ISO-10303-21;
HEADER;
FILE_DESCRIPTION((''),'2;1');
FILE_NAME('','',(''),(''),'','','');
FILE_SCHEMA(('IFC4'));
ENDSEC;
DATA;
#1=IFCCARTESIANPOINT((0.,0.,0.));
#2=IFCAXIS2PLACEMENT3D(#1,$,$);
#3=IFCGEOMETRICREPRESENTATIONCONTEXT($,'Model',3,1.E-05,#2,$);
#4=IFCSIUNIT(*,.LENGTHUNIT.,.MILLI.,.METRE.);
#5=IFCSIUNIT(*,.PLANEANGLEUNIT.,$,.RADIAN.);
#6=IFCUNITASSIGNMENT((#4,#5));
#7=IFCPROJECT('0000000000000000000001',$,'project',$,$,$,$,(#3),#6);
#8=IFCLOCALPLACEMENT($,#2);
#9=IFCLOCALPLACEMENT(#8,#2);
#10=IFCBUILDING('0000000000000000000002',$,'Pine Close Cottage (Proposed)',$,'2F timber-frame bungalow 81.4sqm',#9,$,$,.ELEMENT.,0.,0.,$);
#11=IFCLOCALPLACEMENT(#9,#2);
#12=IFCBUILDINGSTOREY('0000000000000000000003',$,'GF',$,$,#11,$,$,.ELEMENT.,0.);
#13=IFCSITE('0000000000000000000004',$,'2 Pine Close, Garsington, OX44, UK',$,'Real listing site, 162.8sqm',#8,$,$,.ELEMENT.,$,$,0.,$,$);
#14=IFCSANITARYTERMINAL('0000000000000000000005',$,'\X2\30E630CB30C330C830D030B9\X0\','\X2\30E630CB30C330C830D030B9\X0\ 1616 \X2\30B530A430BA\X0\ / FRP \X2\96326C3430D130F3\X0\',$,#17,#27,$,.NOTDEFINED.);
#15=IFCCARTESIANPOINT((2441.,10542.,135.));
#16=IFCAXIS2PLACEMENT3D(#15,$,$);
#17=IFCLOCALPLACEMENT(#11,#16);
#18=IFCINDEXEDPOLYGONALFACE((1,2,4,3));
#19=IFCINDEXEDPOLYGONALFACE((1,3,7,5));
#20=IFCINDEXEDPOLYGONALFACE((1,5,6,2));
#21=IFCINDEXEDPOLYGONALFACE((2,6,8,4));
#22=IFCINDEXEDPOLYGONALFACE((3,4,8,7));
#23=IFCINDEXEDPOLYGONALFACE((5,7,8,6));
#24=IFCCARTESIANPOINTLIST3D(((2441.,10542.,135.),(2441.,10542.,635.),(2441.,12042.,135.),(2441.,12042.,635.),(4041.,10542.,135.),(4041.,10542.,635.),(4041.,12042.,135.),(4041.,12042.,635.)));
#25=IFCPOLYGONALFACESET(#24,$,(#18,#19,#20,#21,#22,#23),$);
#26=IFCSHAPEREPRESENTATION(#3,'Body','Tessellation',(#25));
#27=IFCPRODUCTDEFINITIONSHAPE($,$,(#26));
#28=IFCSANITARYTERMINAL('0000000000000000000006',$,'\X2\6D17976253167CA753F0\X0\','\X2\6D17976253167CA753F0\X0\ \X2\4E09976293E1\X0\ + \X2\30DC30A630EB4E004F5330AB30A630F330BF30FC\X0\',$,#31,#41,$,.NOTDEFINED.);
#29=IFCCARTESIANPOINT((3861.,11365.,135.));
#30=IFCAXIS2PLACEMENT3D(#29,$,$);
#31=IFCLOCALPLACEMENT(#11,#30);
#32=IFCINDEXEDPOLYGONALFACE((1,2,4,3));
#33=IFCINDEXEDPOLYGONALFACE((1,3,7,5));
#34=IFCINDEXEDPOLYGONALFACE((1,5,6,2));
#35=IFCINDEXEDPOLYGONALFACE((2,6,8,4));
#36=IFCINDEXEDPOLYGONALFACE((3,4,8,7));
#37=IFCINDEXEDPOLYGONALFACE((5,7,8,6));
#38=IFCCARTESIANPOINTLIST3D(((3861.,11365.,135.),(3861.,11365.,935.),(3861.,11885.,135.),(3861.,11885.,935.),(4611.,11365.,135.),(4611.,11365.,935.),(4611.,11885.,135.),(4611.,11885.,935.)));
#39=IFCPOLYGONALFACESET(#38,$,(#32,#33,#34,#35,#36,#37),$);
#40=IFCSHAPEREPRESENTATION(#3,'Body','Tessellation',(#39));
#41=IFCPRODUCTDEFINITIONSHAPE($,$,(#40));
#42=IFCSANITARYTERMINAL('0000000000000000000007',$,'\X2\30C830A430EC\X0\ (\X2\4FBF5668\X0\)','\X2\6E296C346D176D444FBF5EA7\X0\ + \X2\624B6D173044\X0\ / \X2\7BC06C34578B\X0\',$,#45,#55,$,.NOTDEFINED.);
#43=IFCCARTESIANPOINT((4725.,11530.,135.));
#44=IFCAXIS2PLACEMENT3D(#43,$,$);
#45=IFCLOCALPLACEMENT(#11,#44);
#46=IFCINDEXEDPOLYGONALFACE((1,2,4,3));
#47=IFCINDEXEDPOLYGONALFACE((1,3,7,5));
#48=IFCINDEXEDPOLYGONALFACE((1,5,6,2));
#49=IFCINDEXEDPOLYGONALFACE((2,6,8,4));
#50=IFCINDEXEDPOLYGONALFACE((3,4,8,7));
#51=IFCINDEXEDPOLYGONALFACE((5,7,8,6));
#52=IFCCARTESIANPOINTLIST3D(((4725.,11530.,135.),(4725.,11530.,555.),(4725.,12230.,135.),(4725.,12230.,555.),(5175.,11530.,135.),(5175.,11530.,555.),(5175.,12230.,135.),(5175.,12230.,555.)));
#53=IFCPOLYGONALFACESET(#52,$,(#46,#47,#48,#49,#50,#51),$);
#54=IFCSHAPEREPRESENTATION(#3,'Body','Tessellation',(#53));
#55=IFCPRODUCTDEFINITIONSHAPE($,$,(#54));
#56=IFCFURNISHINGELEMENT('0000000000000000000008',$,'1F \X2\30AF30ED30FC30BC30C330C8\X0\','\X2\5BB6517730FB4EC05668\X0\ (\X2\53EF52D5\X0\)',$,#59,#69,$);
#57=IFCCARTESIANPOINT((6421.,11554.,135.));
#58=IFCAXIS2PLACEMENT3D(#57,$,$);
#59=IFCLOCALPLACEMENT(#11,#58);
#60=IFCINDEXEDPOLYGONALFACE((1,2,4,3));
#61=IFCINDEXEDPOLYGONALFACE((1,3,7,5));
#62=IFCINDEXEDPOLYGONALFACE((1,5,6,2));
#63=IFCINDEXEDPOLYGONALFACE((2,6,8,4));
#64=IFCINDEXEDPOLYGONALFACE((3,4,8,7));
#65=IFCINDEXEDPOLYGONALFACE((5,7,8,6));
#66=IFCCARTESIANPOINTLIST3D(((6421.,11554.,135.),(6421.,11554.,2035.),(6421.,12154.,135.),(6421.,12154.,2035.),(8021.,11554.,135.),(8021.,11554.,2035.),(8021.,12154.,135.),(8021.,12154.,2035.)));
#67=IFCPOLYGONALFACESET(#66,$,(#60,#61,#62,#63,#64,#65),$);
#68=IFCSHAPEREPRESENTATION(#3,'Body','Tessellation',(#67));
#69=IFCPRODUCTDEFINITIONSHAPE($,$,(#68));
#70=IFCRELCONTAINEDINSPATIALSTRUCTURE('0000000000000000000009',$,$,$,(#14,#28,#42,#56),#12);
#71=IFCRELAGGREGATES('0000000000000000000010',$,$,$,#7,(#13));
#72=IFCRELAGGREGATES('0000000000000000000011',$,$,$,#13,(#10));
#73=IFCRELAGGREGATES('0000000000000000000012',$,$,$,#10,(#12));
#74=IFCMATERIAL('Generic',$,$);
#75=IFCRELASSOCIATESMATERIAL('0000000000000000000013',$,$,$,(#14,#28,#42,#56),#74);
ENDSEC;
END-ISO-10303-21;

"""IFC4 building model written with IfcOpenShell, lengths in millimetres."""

from ifc_helpers import new_model, si_unit, frame, frame_2d, origin, place, context, project, spatial, rectangle, extrude, material, element, save


model = new_model("IFC4")

# Units and contexts
model_context = context("Model", 3, precision=1e-05, world=origin())
ifc_project = project(units=[si_unit("LENGTHUNIT", "METRE", prefix="MILLI"), si_unit("PLANEANGLEUNIT", "RADIAN")], contexts=[model_context])

# Site, building, storey
site_placement = place(None, origin())
site = spatial("IfcSite", under=ifc_project, at=site_placement, Name="2 Pine Close, Garsington, OX44, UK", ObjectType="Real listing site, 162.8sqm", CompositionType="ELEMENT", RefElevation=0.0)
building_placement = place(site_placement, origin())
building = spatial("IfcBuilding", under=site, at=building_placement, Name="Pine Close Cottage (Proposed)", ObjectType="2F timber-frame bungalow 81.4sqm", CompositionType="ELEMENT", ElevationOfRefHeight=0.0, ElevationOfTerrain=0.0)
storey_placement = place(building_placement, origin())
storey = spatial("IfcBuildingStorey", under=building, at=storey_placement, Name="GF", CompositionType="ELEMENT", Elevation=0.0)

# Shared definitions
ifc_material_1 = material(Name="Generic")

# Sanitary terminals
sanitary_terminal_1_placement = place(storey_placement, frame((2441.0, 10542.0, 135.0)))
element("IfcSanitaryTerminal", 1, at=sanitary_terminal_1_placement, inside=storey, material=ifc_material_1, Name="ユニットバス", Description="ユニットバス 1616 サイズ / FRP 防水パン", PredefinedType="NOTDEFINED", context=model_context, shape_type="SweptSolid", body=[
    extrude(rectangle(XDim=1600.0, YDim=1500.0, at=frame_2d((800.0, 750.0))), frame((2441.0, 10542.0, 135.0)), (0.0, 0.0, 1.0), 500.0),
])
sanitary_terminal_2_placement = place(storey_placement, frame((3861.0, 11365.0, 135.0)))
element("IfcSanitaryTerminal", 2, at=sanitary_terminal_2_placement, inside=storey, material=ifc_material_1, Name="洗面化粧台", Description="洗面化粧台 三面鏡 + ボウル一体カウンター", PredefinedType="NOTDEFINED", context=model_context, shape_type="SweptSolid", body=[
    extrude(rectangle(XDim=750.0, YDim=520.0, at=frame_2d((375.0, 260.0))), frame((3861.0, 11365.0, 135.0)), (0.0, 0.0, 1.0), 800.0),
])
sanitary_terminal_3_placement = place(storey_placement, frame((4725.0, 11530.0, 135.0)))
element("IfcSanitaryTerminal", 3, at=sanitary_terminal_3_placement, inside=storey, material=ifc_material_1, Name="トイレ (便器)", Description="温水洗浄便座 + 手洗い / 節水型", PredefinedType="NOTDEFINED", context=model_context, shape_type="SweptSolid", body=[
    extrude(rectangle(XDim=450.0, YDim=700.0, at=frame_2d((225.0, 350.0))), frame((4725.0, 11530.0, 135.0)), (0.0, 0.0, 1.0), 420.0),
])

# Furnishing element
furnishing_placement = place(storey_placement, frame((6421.0, 11554.0, 135.0)))
element("IfcFurnishingElement", 4, at=furnishing_placement, inside=storey, material=ifc_material_1, Name="1F クローゼット", Description="家具・什器 (可動)", context=model_context, shape_type="SweptSolid", body=[
    extrude(rectangle(XDim=1600.0, YDim=600.0, at=frame_2d((800.0, 300.0))), frame((6421.0, 11554.0, 135.0)), (0.0, 0.0, 1.0), 1900.0),
])

save(model, "model.ifc")
